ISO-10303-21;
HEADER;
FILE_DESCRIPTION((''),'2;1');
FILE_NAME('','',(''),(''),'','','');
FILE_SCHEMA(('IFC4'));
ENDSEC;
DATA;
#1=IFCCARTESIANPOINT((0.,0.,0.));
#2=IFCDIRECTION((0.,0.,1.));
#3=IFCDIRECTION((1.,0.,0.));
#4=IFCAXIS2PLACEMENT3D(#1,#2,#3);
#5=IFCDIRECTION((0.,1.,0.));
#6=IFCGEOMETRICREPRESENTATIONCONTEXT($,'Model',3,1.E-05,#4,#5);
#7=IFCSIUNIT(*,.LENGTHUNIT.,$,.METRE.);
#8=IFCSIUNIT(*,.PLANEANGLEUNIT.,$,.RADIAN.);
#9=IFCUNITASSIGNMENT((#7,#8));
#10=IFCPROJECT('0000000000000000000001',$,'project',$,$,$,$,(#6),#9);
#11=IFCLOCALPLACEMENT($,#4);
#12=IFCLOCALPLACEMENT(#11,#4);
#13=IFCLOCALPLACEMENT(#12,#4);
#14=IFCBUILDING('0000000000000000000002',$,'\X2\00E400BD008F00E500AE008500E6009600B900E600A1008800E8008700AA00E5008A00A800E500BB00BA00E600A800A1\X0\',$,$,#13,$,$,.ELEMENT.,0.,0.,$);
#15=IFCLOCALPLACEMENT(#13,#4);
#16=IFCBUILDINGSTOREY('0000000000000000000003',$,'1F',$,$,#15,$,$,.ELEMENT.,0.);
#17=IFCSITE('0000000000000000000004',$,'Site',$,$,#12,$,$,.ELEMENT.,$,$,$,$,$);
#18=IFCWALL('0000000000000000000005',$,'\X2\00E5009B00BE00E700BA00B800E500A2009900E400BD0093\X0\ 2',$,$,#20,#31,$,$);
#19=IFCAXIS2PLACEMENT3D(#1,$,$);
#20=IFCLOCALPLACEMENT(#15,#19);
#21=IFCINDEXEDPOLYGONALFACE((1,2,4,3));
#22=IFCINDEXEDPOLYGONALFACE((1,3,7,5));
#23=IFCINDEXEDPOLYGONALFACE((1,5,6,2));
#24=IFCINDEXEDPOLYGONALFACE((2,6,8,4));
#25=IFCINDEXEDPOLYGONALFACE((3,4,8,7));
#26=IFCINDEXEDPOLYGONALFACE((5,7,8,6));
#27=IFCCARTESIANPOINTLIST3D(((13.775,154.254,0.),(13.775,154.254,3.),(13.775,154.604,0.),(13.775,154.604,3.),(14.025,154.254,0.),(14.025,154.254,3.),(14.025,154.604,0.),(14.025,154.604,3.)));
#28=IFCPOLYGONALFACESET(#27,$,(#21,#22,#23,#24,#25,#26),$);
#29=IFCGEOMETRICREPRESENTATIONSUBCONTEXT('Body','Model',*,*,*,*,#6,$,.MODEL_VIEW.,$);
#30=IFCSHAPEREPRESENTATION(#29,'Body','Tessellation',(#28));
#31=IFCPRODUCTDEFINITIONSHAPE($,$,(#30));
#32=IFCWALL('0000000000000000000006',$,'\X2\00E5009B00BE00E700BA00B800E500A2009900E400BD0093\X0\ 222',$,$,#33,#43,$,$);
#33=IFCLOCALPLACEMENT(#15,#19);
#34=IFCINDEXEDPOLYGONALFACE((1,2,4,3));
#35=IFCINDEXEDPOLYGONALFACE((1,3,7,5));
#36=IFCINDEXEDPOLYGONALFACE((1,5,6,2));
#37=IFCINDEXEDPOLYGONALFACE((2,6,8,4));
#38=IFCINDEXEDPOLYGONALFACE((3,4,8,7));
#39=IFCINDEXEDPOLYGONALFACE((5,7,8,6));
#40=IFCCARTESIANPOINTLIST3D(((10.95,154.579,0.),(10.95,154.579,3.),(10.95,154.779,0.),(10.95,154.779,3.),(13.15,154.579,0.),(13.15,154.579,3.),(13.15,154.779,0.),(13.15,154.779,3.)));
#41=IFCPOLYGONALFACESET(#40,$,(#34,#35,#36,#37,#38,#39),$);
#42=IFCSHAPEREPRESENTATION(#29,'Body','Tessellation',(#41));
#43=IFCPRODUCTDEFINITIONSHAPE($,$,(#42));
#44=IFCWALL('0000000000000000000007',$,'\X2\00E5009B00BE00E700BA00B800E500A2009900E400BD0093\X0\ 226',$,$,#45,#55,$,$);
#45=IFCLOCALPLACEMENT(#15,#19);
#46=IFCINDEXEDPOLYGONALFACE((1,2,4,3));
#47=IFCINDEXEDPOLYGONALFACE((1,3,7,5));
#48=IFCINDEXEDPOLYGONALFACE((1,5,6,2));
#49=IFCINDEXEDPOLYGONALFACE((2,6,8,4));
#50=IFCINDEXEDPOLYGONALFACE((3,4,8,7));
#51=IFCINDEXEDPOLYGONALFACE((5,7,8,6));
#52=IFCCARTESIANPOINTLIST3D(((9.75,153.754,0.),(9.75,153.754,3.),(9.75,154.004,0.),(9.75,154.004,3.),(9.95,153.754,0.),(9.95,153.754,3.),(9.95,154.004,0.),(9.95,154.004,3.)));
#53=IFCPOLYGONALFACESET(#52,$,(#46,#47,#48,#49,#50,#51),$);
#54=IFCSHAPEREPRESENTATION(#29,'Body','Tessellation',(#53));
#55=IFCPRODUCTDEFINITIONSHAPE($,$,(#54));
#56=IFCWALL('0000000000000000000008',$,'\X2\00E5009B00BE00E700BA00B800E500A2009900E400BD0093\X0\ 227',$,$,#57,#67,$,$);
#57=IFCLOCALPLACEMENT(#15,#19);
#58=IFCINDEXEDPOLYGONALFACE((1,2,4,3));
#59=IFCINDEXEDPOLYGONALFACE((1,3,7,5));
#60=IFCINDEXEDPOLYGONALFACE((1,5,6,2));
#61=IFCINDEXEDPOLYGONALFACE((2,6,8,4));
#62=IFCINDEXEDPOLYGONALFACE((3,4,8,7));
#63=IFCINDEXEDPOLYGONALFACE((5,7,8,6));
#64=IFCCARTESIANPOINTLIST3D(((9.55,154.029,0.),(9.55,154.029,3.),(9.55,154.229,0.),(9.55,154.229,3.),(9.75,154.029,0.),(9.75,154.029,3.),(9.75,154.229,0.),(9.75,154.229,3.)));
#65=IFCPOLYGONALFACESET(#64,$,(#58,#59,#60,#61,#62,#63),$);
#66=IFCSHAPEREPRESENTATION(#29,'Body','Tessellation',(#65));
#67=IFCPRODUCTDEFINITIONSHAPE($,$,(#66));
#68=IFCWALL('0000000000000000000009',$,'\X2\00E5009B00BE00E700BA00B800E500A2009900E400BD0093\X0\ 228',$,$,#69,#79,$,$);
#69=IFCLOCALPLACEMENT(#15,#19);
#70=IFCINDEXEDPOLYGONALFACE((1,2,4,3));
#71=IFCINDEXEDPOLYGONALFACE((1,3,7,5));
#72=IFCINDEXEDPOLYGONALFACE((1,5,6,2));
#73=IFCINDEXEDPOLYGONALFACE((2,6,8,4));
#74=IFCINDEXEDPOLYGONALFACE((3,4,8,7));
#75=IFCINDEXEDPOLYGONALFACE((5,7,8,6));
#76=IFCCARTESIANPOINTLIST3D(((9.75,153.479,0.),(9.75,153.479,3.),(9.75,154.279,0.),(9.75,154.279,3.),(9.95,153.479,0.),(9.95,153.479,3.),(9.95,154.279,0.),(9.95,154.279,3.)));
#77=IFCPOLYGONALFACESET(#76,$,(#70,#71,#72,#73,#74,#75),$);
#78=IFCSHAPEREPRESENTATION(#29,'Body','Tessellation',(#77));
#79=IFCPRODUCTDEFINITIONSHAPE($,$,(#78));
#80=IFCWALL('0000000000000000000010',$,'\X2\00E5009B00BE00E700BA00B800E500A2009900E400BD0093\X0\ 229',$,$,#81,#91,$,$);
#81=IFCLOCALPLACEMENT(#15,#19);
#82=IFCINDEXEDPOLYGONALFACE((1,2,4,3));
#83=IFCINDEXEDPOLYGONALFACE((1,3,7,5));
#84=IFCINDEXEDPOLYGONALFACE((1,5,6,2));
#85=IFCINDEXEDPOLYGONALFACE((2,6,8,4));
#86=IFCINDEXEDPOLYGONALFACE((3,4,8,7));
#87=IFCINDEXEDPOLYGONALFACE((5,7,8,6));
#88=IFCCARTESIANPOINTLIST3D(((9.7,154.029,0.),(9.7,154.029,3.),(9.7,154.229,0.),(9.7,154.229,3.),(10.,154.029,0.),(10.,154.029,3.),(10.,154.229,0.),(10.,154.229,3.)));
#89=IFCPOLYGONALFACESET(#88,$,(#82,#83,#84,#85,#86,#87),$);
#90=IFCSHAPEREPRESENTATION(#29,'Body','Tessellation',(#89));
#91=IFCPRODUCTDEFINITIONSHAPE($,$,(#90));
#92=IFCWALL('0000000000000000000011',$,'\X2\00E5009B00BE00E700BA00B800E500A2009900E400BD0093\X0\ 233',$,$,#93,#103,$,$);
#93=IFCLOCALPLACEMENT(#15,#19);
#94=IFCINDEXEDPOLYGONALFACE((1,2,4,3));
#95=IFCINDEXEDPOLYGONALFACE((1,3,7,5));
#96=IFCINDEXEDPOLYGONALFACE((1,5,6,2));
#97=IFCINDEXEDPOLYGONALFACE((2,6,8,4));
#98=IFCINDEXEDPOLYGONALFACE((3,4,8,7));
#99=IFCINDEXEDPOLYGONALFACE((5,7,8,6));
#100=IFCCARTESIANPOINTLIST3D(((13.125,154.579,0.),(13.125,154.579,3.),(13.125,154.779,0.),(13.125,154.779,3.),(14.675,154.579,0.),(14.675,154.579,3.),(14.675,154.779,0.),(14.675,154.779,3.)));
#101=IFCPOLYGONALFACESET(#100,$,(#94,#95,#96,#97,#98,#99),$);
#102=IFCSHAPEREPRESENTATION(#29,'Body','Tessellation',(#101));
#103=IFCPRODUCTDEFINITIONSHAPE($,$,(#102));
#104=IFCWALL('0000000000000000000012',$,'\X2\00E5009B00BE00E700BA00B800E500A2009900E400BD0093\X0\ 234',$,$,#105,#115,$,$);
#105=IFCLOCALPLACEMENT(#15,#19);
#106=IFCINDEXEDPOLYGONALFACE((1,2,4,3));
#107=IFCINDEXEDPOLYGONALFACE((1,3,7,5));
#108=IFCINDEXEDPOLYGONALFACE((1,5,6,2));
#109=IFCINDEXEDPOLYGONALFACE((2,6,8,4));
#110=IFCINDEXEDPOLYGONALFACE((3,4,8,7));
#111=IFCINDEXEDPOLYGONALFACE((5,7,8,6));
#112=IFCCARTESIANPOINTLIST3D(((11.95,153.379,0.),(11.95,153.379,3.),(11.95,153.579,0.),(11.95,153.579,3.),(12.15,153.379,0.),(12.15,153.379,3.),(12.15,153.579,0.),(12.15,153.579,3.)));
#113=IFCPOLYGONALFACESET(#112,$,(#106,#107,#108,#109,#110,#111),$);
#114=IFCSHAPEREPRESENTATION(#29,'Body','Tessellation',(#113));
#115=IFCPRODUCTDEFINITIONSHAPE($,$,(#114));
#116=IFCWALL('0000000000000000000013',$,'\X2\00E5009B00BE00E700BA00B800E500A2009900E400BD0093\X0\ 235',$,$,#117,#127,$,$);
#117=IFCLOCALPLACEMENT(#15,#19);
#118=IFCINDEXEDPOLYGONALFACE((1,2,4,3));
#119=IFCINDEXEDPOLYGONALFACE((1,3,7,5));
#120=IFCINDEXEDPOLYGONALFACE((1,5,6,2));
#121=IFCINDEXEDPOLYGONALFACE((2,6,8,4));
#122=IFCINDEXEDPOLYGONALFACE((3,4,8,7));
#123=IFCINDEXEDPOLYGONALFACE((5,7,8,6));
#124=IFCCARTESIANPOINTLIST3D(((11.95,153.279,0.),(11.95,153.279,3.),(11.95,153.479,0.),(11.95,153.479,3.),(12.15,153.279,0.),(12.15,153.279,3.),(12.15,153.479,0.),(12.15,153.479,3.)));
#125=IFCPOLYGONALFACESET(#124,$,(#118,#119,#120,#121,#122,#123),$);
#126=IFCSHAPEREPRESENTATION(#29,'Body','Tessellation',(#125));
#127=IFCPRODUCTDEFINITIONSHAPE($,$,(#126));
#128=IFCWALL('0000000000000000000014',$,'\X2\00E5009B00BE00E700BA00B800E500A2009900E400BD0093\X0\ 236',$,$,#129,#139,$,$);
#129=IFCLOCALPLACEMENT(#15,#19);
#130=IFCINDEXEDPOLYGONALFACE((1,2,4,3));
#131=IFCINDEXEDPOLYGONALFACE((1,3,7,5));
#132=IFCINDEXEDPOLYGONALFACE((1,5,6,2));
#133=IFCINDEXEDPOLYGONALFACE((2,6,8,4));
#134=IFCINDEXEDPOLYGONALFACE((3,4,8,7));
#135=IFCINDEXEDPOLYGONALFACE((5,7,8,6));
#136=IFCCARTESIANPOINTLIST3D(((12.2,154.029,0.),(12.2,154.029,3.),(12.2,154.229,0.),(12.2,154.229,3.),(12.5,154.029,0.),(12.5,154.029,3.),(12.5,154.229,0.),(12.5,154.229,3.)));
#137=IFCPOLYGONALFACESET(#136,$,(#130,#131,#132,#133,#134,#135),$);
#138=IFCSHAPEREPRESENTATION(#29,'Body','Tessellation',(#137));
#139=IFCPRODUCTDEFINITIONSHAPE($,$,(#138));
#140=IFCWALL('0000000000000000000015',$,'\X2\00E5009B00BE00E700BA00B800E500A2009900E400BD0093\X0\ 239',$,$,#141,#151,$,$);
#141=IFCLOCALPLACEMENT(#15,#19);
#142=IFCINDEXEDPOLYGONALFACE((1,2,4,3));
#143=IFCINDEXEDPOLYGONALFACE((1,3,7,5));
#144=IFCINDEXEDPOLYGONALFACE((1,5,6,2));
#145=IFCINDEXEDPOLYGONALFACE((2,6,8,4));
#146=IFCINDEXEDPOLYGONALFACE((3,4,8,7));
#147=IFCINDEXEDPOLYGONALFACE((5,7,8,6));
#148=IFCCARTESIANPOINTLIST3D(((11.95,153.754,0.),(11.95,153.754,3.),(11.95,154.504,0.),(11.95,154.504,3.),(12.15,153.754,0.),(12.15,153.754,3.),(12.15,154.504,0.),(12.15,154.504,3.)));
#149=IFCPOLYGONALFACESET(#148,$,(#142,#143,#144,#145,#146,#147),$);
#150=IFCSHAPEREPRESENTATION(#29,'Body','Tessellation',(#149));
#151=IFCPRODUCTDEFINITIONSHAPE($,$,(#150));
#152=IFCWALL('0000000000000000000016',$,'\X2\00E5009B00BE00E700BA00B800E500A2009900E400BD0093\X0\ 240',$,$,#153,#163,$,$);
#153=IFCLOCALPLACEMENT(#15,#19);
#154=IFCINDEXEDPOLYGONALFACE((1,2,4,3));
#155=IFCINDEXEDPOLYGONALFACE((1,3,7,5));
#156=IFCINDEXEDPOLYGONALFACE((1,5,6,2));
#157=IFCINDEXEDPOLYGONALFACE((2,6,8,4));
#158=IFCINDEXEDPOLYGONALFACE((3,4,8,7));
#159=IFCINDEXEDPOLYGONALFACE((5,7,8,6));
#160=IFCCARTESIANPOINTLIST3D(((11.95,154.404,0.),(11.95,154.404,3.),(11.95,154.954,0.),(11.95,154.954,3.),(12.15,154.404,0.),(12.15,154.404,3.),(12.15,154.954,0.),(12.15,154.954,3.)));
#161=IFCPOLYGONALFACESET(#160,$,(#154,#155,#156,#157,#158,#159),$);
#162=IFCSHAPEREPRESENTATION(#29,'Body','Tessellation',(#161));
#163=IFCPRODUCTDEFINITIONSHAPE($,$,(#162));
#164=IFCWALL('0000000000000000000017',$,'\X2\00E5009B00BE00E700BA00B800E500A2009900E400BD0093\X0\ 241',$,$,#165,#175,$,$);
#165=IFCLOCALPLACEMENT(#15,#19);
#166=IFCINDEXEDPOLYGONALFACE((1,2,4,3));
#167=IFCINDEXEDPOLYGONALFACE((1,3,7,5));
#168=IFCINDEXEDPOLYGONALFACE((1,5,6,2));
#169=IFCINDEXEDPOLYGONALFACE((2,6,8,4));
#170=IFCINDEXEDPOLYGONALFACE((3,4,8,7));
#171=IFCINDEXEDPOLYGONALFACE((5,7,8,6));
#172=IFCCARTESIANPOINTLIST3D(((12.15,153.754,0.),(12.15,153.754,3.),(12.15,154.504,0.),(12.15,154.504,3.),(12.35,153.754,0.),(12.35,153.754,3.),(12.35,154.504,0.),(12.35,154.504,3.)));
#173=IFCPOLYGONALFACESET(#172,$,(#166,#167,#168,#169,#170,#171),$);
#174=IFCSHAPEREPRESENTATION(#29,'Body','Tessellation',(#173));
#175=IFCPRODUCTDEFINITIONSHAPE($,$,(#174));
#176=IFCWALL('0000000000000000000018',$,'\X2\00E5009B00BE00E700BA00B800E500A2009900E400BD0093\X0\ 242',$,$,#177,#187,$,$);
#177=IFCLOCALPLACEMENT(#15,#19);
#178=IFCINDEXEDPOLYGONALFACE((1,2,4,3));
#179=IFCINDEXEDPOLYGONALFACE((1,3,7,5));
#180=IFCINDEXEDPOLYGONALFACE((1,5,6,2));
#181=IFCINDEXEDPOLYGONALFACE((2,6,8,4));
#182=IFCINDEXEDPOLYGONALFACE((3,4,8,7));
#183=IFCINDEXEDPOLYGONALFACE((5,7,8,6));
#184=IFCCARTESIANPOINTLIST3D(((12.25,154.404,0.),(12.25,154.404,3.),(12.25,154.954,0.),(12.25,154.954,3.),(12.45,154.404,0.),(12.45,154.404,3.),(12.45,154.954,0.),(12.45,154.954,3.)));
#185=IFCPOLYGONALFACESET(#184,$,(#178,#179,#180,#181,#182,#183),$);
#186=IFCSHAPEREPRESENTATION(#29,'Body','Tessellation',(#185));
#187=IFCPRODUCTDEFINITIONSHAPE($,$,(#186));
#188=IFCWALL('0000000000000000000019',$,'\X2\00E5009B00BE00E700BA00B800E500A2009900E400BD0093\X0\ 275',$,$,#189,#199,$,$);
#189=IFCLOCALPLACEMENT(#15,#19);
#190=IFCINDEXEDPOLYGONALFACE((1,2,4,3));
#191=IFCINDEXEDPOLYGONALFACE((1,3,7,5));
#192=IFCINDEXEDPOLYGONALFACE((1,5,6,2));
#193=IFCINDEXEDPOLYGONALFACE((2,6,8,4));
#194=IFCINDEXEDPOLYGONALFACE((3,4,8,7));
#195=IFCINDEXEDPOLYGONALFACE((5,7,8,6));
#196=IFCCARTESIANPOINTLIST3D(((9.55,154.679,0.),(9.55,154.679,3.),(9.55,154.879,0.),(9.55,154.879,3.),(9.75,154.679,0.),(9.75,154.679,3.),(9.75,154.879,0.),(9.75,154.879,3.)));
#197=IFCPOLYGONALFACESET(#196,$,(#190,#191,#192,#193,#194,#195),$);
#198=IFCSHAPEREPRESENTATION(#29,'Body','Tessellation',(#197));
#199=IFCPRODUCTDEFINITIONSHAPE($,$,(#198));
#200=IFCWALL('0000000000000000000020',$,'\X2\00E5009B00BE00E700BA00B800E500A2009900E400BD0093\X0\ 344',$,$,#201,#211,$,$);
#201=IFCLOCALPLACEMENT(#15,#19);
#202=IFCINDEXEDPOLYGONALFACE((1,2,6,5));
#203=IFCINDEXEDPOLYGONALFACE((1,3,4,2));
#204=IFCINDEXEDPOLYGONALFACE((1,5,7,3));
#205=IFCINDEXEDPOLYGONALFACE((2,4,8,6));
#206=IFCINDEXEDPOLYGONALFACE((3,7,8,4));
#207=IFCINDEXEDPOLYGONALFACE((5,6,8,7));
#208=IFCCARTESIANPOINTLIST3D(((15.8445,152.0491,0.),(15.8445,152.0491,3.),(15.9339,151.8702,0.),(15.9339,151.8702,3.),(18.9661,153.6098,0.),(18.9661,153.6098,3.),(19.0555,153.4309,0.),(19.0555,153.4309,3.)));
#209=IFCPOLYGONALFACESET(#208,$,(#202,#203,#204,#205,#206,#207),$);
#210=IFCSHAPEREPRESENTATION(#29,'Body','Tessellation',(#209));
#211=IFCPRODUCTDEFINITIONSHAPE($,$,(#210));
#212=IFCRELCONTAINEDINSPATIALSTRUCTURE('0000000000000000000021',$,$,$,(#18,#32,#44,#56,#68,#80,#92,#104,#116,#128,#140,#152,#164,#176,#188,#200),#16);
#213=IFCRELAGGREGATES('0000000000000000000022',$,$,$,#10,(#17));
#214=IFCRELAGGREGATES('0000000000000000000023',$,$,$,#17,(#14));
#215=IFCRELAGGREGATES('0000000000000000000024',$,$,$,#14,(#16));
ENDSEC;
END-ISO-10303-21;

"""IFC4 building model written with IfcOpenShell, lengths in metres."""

from ifc_helpers import new_model, si_unit, direction, frame, frame_2d, origin_with_axes, place, context, subcontext, project, spatial, rectangle, extrude, element, save


model = new_model("IFC4")

# Units and contexts
model_context = context("Model", 3, precision=1e-05, world=origin_with_axes(), true_north=direction((0.0, 1.0, 0.0)))
body_context = subcontext(model_context, "Body", "Model", "MODEL_VIEW")
ifc_project = project(units=[si_unit("LENGTHUNIT", "METRE"), si_unit("PLANEANGLEUNIT", "RADIAN")], contexts=[model_context])

# Site, building, storey
placement = place(None, origin_with_axes())
site_placement = place(placement, origin_with_axes())
site = spatial("IfcSite", under=ifc_project, at=site_placement, Name="Site", CompositionType="ELEMENT")
building_placement = place(site_placement, origin_with_axes())
building = spatial("IfcBuilding", under=site, at=building_placement, Name="ä½\u008få®\u0085æ\u0096¹æ¡\u0088è\u0087ªå\u008a¨å»ºæ¨¡", CompositionType="ELEMENT", ElevationOfRefHeight=0.0, ElevationOfTerrain=0.0)
storey_placement = place(building_placement, origin_with_axes())
storey = spatial("IfcBuildingStorey", under=building, at=storey_placement, Name="1F", CompositionType="ELEMENT", Elevation=0.0)

# Walls
for number, where, z_axis, x_axis, name in (
    (1, (13.9, 154.429, 0.0), (0.0, 0.0, 1.0), (1.0, 0.0, 0.0), "å\u009b¾çº¸å¢\u0099ä½\u0093 2"),
):
    element("IfcWall", number, at=place(storey_placement, frame(where, z_axis=z_axis, x_axis=x_axis)), inside=storey, Name=name, context=body_context, shape_type="SweptSolid", body=[
        extrude(rectangle(XDim=0.25, YDim=0.35, at=frame_2d((0.0, 0.0), x_axis=(1.0, 0.0, 0.0))), frame((0.0, 0.0, 0.0), z_axis=(0.0, 0.0, 1.0)), (0.0, 0.0, 1.0), 3.0),
    ])
wall_1_placement = place(storey_placement, frame((12.05, 154.679, 0.0), z_axis=(0.0, 0.0, 1.0), x_axis=(-1.0, 0.0, 0.0)))
element("IfcWall", 2, at=wall_1_placement, inside=storey, Name="å\u009b¾çº¸å¢\u0099ä½\u0093 222", context=body_context, shape_type="SweptSolid", body=[
    extrude(rectangle(XDim=2.2, YDim=0.2, at=frame_2d((0.0, 0.0), x_axis=(1.0, 0.0, 0.0))), frame((0.0, 0.0, 0.0), z_axis=(0.0, 0.0, 1.0)), (0.0, 0.0, 1.0), 3.0),
])
wall_2_placement = place(storey_placement, frame((9.85, 153.879, 0.0), z_axis=(0.0, 0.0, 1.0), x_axis=(0.0, 1.0, 0.0)))
element("IfcWall", 3, at=wall_2_placement, inside=storey, Name="å\u009b¾çº¸å¢\u0099ä½\u0093 226", context=body_context, shape_type="SweptSolid", body=[
    extrude(rectangle(XDim=0.25, YDim=0.2, at=frame_2d((0.0, 0.0), x_axis=(1.0, 0.0, 0.0))), frame((0.0, 0.0, 0.0), z_axis=(0.0, 0.0, 1.0)), (0.0, 0.0, 1.0), 3.0),
])
wall_3_placement = place(storey_placement, frame((9.65, 154.129, 0.0), z_axis=(0.0, 0.0, 1.0), x_axis=(1.0, 0.0, 0.0)))
element("IfcWall", 4, at=wall_3_placement, inside=storey, Name="å\u009b¾çº¸å¢\u0099ä½\u0093 227", context=body_context, shape_type="SweptSolid", body=[
    extrude(rectangle(XDim=0.2, YDim=0.2, at=frame_2d((0.0, 0.0), x_axis=(1.0, 0.0, 0.0))), frame((0.0, 0.0, 0.0), z_axis=(0.0, 0.0, 1.0)), (0.0, 0.0, 1.0), 3.0),
])
wall_4_placement = place(storey_placement, frame((9.85, 153.879, 0.0), z_axis=(0.0, 0.0, 1.0), x_axis=(0.0, 1.0, 0.0)))
element("IfcWall", 5, at=wall_4_placement, inside=storey, Name="å\u009b¾çº¸å¢\u0099ä½\u0093 228", context=body_context, shape_type="SweptSolid", body=[
    extrude(rectangle(XDim=0.8, YDim=0.2, at=frame_2d((0.0, 0.0), x_axis=(1.0, 0.0, 0.0))), frame((0.0, 0.0, 0.0), z_axis=(0.0, 0.0, 1.0)), (0.0, 0.0, 1.0), 3.0),
])
wall_5_placement = place(storey_placement, frame((9.85, 154.129, 0.0), z_axis=(0.0, 0.0, 1.0), x_axis=(-1.0, 0.0, 0.0)))
element("IfcWall", 6, at=wall_5_placement, inside=storey, Name="å\u009b¾çº¸å¢\u0099ä½\u0093 229", context=body_context, shape_type="SweptSolid", body=[
    extrude(rectangle(XDim=0.3, YDim=0.2, at=frame_2d((0.0, 0.0), x_axis=(1.0, 0.0, 0.0))), frame((0.0, 0.0, 0.0), z_axis=(0.0, 0.0, 1.0)), (0.0, 0.0, 1.0), 3.0),
])
wall_6_placement = place(storey_placement, frame((13.9, 154.679, 0.0), z_axis=(0.0, 0.0, 1.0), x_axis=(-1.0, 0.0, 0.0)))
element("IfcWall", 7, at=wall_6_placement, inside=storey, Name="å\u009b¾çº¸å¢\u0099ä½\u0093 233", context=body_context, shape_type="SweptSolid", body=[
    extrude(rectangle(XDim=1.55, YDim=0.2, at=frame_2d((0.0, 0.0), x_axis=(1.0, 0.0, 0.0))), frame((0.0, 0.0, 0.0), z_axis=(0.0, 0.0, 1.0)), (0.0, 0.0, 1.0), 3.0),
])
for number, where, z_axis, x_axis, name in (
    (8, (12.05, 153.479, 0.0), (0.0, 0.0, 1.0), (1.0, 0.0, 0.0), "å\u009b¾çº¸å¢\u0099ä½\u0093 234"),
    (9, (12.05, 153.379, 0.0), (0.0, 0.0, 1.0), (1.0, 0.0, 0.0), "å\u009b¾çº¸å¢\u0099ä½\u0093 235"),
):
    element("IfcWall", number, at=place(storey_placement, frame(where, z_axis=z_axis, x_axis=x_axis)), inside=storey, Name=name, context=body_context, shape_type="SweptSolid", body=[
        extrude(rectangle(XDim=0.2, YDim=0.2, at=frame_2d((0.0, 0.0), x_axis=(1.0, 0.0, 0.0))), frame((0.0, 0.0, 0.0), z_axis=(0.0, 0.0, 1.0)), (0.0, 0.0, 1.0), 3.0),
    ])
wall_7_placement = place(storey_placement, frame((12.35, 154.129, 0.0), z_axis=(0.0, 0.0, 1.0), x_axis=(-1.0, 0.0, 0.0)))
element("IfcWall", 10, at=wall_7_placement, inside=storey, Name="å\u009b¾çº¸å¢\u0099ä½\u0093 236", context=body_context, shape_type="SweptSolid", body=[
    extrude(rectangle(XDim=0.3, YDim=0.2, at=frame_2d((0.0, 0.0), x_axis=(1.0, 0.0, 0.0))), frame((0.0, 0.0, 0.0), z_axis=(0.0, 0.0, 1.0)), (0.0, 0.0, 1.0), 3.0),
])
wall_8_placement = place(storey_placement, frame((12.05, 154.129, 0.0), z_axis=(0.0, 0.0, 1.0), x_axis=(0.0, -1.0, 0.0)))
element("IfcWall", 11, at=wall_8_placement, inside=storey, Name="å\u009b¾çº¸å¢\u0099ä½\u0093 239", context=body_context, shape_type="SweptSolid", body=[
    extrude(rectangle(XDim=0.75, YDim=0.2, at=frame_2d((0.0, 0.0), x_axis=(1.0, 0.0, 0.0))), frame((0.0, 0.0, 0.0), z_axis=(0.0, 0.0, 1.0)), (0.0, 0.0, 1.0), 3.0),
])
wall_9_placement = place(storey_placement, frame((12.05, 154.679, 0.0), z_axis=(0.0, 0.0, 1.0), x_axis=(0.0, -1.0, 0.0)))
element("IfcWall", 12, at=wall_9_placement, inside=storey, Name="å\u009b¾çº¸å¢\u0099ä½\u0093 240", context=body_context, shape_type="SweptSolid", body=[
    extrude(rectangle(XDim=0.55, YDim=0.2, at=frame_2d((0.0, 0.0), x_axis=(1.0, 0.0, 0.0))), frame((0.0, 0.0, 0.0), z_axis=(0.0, 0.0, 1.0)), (0.0, 0.0, 1.0), 3.0),
])
wall_10_placement = place(storey_placement, frame((12.25, 154.129, 0.0), z_axis=(0.0, 0.0, 1.0), x_axis=(0.0, -1.0, 0.0)))
element("IfcWall", 13, at=wall_10_placement, inside=storey, Name="å\u009b¾çº¸å¢\u0099ä½\u0093 241", context=body_context, shape_type="SweptSolid", body=[
    extrude(rectangle(XDim=0.75, YDim=0.2, at=frame_2d((0.0, 0.0), x_axis=(1.0, 0.0, 0.0))), frame((0.0, 0.0, 0.0), z_axis=(0.0, 0.0, 1.0)), (0.0, 0.0, 1.0), 3.0),
])
wall_11_placement = place(storey_placement, frame((12.35, 154.679, 0.0), z_axis=(0.0, 0.0, 1.0), x_axis=(0.0, -1.0, 0.0)))
element("IfcWall", 14, at=wall_11_placement, inside=storey, Name="å\u009b¾çº¸å¢\u0099ä½\u0093 242", context=body_context, shape_type="SweptSolid", body=[
    extrude(rectangle(XDim=0.55, YDim=0.2, at=frame_2d((0.0, 0.0), x_axis=(1.0, 0.0, 0.0))), frame((0.0, 0.0, 0.0), z_axis=(0.0, 0.0, 1.0)), (0.0, 0.0, 1.0), 3.0),
])
wall_12_placement = place(storey_placement, frame((9.65, 154.779, 0.0), z_axis=(0.0, 0.0, 1.0), x_axis=(1.0, 0.0, 0.0)))
element("IfcWall", 15, at=wall_12_placement, inside=storey, Name="å\u009b¾çº¸å¢\u0099ä½\u0093 275", context=body_context, shape_type="SweptSolid", body=[
    extrude(rectangle(XDim=0.2, YDim=0.2, at=frame_2d((0.0, 0.0), x_axis=(1.0, 0.0, 0.0))), frame((0.0, 0.0, 0.0), z_axis=(0.0, 0.0, 1.0)), (0.0, 0.0, 1.0), 3.0),
])
wall_13_placement = place(storey_placement, frame((17.45, 152.74, 0.0), z_axis=(0.0, 0.0, 1.0), x_axis=(-0.894428, -0.447213, 0.0)))
element("IfcWall", 16, at=wall_13_placement, inside=storey, Name="å\u009b¾çº¸å¢\u0099ä½\u0093 344", context=body_context, shape_type="SweptSolid", body=[
    extrude(rectangle(XDim=3.49, YDim=0.2, at=frame_2d((0.0, 0.0), x_axis=(1.0, 0.0, 0.0))), frame((0.0, 0.0, 0.0), z_axis=(0.0, 0.0, 1.0)), (0.0, 0.0, 1.0), 3.0),
])

save(model, "model.ifc")
